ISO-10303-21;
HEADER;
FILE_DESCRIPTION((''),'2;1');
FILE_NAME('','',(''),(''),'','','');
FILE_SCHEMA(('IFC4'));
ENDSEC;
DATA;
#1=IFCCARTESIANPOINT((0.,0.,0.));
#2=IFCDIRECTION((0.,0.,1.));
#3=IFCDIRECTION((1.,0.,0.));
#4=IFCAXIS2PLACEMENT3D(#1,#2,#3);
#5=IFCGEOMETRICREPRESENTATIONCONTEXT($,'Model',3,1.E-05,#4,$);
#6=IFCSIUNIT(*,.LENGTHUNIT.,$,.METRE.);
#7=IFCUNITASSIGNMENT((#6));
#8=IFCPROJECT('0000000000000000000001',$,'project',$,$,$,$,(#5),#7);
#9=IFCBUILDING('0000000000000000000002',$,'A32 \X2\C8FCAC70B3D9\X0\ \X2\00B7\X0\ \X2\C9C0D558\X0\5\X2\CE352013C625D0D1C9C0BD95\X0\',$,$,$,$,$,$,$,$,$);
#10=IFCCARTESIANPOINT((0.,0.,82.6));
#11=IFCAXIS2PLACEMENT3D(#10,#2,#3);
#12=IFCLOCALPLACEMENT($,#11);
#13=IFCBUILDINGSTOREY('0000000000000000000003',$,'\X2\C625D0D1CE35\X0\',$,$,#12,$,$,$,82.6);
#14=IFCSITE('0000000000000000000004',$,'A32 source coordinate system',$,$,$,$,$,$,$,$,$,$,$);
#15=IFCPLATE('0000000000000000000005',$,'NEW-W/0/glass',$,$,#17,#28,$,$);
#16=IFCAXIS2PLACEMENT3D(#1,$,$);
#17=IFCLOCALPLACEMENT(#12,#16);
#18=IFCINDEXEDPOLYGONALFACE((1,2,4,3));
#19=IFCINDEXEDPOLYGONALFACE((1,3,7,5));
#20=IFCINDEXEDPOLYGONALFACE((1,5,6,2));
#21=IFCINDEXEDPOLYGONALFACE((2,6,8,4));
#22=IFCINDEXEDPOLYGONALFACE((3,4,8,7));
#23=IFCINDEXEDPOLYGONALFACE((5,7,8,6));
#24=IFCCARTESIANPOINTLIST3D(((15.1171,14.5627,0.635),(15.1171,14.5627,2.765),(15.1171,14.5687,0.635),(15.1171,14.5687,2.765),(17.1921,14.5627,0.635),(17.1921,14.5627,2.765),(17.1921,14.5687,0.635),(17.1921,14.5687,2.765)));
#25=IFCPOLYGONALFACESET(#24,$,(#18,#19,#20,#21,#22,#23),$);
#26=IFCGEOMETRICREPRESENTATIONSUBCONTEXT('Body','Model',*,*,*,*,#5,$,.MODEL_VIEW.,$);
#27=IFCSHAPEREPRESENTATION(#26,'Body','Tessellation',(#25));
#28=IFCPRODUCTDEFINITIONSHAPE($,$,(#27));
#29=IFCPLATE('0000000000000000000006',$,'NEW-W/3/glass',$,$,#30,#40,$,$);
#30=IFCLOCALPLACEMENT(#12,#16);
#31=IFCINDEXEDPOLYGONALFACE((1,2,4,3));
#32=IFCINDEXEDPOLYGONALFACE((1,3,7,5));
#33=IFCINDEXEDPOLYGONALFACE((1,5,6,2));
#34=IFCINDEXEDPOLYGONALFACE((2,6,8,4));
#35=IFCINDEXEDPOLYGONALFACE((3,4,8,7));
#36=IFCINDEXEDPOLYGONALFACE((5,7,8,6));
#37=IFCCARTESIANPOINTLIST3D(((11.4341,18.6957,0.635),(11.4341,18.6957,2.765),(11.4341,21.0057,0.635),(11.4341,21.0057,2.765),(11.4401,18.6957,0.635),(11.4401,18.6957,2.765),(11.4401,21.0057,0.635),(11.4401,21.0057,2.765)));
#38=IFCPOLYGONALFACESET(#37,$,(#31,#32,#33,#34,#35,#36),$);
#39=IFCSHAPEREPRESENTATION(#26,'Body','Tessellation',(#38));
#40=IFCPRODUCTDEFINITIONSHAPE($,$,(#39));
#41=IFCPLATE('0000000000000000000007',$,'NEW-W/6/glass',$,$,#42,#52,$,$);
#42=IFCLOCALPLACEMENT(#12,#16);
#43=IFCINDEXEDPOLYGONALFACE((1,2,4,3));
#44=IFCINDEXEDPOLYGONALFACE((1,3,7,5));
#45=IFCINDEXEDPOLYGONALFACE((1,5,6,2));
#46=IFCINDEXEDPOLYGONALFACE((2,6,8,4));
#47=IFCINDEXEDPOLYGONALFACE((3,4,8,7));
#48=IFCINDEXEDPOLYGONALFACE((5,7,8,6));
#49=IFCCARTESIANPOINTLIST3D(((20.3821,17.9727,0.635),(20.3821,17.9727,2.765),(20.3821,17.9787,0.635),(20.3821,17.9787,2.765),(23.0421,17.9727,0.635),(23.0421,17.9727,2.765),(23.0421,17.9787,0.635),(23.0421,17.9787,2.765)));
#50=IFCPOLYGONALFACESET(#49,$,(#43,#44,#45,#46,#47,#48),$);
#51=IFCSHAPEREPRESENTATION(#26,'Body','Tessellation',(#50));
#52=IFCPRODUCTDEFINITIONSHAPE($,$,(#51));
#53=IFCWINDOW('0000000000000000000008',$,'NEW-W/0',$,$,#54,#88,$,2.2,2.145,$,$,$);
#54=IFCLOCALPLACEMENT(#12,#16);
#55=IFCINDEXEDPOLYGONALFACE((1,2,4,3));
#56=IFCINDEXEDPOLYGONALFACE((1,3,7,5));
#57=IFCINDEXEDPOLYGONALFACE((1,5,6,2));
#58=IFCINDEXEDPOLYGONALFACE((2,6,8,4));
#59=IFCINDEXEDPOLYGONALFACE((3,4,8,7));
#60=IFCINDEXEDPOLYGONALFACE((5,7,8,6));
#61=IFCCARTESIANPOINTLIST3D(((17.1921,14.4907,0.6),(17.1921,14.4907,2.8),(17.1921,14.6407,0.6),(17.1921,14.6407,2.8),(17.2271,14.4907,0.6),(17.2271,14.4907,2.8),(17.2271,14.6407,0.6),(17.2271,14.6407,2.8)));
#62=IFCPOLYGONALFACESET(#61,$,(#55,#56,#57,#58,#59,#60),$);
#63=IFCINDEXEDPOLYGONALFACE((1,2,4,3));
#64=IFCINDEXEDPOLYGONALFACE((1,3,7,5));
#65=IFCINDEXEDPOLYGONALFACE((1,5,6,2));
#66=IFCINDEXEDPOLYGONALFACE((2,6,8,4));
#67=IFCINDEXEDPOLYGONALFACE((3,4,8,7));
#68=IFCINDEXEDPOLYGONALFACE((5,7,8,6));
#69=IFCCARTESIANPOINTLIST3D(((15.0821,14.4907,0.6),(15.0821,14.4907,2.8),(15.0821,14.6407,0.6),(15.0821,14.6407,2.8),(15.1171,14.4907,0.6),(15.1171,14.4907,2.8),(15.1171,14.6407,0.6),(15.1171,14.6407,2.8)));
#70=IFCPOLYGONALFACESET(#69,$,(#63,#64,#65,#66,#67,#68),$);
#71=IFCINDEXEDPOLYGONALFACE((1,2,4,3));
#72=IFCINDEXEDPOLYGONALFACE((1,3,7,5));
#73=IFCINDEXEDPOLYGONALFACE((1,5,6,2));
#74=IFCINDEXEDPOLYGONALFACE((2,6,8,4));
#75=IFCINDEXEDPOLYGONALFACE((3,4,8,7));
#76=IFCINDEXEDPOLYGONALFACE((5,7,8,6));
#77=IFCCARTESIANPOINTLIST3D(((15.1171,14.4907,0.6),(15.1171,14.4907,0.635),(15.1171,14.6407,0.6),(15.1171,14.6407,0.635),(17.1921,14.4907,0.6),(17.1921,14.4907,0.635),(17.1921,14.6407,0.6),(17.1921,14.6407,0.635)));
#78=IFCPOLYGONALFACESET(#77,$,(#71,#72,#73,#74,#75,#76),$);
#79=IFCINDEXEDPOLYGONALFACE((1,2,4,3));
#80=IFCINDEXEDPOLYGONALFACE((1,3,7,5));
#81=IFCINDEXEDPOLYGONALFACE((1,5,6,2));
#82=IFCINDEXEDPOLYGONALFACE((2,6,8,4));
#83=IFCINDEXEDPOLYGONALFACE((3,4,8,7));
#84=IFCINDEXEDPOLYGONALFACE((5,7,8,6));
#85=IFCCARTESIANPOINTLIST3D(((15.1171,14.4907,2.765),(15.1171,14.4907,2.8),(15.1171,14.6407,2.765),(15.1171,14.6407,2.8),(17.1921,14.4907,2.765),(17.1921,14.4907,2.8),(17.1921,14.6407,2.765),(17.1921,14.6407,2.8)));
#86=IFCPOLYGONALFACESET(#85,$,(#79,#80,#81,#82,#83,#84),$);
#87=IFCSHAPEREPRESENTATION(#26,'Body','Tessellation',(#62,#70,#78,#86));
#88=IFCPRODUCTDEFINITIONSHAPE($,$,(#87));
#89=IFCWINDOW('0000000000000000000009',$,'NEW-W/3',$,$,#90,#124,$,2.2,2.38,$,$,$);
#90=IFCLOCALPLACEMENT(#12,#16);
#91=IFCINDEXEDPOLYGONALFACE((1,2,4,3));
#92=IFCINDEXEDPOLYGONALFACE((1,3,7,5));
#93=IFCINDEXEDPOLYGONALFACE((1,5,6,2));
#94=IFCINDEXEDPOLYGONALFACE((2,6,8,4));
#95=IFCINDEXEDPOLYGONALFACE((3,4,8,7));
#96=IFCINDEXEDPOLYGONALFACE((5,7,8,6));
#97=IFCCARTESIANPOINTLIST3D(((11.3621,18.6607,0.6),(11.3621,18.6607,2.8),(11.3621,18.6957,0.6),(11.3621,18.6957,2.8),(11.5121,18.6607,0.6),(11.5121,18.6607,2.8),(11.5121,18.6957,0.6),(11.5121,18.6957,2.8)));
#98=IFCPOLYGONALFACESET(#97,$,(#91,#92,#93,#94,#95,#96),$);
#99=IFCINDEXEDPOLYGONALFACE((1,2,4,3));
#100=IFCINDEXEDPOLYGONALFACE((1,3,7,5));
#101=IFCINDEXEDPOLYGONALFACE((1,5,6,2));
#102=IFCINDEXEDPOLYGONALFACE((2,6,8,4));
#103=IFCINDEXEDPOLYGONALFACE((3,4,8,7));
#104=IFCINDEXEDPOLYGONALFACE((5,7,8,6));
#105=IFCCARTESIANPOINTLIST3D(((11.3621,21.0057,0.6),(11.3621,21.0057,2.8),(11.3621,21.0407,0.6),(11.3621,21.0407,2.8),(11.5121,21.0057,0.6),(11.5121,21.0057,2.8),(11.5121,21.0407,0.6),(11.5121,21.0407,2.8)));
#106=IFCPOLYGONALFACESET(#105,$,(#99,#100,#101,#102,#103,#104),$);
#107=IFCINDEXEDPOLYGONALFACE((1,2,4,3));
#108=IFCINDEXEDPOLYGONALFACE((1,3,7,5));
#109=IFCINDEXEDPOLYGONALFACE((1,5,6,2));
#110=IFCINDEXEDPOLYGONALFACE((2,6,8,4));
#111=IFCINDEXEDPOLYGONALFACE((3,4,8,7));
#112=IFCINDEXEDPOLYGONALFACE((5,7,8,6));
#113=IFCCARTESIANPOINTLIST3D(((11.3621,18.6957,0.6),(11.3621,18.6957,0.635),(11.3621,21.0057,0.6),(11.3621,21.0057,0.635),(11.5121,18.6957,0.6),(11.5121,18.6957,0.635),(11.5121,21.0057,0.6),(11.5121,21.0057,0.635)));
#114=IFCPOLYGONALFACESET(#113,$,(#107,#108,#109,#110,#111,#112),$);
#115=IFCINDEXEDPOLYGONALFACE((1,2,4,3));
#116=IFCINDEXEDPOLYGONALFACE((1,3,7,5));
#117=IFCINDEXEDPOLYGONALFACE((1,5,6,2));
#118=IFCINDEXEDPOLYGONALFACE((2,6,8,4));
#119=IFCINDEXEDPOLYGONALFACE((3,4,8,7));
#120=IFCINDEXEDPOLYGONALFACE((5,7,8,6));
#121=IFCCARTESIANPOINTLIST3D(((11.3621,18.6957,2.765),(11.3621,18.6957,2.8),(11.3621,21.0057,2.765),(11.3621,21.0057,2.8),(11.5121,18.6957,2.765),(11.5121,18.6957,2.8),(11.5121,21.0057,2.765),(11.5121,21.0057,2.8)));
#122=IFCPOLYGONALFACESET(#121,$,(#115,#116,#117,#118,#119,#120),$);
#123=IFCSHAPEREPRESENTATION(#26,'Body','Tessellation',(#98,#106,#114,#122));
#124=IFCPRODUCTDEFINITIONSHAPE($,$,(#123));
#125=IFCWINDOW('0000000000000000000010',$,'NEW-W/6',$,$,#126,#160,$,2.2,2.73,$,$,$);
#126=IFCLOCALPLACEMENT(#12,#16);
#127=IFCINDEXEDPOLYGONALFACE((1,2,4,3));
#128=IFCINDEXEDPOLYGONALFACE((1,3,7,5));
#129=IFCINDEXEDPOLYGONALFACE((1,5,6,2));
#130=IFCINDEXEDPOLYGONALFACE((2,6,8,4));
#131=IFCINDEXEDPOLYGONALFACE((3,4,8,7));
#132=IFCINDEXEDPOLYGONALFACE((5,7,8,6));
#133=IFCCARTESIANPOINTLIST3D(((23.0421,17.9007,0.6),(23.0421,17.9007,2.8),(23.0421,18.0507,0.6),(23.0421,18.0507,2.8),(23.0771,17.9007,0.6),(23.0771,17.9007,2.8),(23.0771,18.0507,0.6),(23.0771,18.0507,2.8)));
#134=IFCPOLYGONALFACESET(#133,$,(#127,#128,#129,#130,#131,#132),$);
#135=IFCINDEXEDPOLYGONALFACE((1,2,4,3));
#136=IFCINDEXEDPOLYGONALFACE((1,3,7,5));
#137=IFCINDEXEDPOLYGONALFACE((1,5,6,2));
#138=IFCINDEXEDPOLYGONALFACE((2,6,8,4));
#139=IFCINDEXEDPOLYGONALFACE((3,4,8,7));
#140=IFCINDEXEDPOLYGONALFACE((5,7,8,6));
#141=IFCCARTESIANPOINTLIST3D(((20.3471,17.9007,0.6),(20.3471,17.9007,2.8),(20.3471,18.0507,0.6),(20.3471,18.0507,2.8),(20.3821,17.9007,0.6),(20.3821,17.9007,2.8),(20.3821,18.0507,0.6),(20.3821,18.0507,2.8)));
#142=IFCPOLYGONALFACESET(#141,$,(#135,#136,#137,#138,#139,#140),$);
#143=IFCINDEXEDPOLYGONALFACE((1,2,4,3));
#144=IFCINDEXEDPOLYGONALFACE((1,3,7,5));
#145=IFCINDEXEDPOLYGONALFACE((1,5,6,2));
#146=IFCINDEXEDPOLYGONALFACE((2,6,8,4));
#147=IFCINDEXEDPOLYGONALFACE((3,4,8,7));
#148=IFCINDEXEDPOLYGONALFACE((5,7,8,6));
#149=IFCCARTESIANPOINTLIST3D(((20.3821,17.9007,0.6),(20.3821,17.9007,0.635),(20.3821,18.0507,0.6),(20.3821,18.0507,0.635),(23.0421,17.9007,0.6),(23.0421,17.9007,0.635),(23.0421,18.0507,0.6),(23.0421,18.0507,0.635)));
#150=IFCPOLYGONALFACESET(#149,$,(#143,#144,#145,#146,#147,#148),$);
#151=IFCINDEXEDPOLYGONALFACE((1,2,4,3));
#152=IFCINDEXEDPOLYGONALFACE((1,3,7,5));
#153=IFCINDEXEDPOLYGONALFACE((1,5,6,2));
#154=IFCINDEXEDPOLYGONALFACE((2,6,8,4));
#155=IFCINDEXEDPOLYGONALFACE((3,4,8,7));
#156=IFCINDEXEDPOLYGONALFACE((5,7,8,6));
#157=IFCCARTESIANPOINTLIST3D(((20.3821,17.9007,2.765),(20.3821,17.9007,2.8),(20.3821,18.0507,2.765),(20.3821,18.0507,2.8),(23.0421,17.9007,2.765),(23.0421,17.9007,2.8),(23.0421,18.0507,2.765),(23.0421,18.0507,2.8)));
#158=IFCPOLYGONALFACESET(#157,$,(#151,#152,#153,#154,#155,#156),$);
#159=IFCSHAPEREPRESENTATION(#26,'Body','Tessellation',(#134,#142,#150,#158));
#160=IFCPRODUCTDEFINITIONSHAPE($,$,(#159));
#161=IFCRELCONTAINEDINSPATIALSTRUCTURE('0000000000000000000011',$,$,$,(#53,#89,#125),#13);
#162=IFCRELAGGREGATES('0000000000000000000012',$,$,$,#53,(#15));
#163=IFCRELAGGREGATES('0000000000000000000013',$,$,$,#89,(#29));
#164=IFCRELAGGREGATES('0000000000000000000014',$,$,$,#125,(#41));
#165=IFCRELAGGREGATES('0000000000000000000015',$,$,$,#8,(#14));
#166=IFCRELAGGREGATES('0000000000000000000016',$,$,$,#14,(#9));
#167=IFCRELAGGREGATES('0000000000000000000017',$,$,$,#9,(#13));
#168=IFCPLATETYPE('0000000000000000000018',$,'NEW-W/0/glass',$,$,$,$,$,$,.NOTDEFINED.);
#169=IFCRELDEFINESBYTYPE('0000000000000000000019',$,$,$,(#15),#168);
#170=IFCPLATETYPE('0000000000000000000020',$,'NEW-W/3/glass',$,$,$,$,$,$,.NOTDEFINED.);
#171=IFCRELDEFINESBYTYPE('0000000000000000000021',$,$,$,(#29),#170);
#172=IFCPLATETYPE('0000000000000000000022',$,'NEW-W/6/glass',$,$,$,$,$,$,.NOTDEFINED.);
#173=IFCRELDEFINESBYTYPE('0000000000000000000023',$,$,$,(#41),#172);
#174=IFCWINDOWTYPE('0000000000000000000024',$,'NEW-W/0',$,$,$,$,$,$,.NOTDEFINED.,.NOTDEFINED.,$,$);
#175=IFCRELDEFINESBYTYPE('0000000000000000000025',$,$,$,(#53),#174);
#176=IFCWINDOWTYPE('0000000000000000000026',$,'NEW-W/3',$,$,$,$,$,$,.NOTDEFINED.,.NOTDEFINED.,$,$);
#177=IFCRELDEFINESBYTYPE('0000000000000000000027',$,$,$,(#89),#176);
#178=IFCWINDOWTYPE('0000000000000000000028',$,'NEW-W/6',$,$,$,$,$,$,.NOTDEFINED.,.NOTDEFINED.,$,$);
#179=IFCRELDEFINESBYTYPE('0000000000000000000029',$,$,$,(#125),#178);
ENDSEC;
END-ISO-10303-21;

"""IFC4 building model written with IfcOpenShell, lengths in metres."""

from ifc_helpers import new_model, si_unit, frame, origin, origin_with_axes, place, context, subcontext, project, spatial, polyline, outline, extrude, source, transform, mapped, type_object, type_shapes, element, aggregate, save


model = new_model("IFC4")

# Units and contexts
model_context = context("Model", 3, precision=1e-05, world=origin_with_axes())
body_context = subcontext(model_context, "Body", "Model", "MODEL_VIEW")
ifc_project = project(units=[si_unit("LENGTHUNIT", "METRE")], contexts=[model_context])

# Plates
plate_type_1 = type_object("IfcPlateType", Name="NEW-W/0/glass", PredefinedType="NOTDEFINED")
shared_shape_1 = source(origin(), body_context, "Body", "SweptSolid", [
    extrude(outline(polyline([(17.1921, 14.5627), (15.1171, 14.5627), (15.1171, 14.5687), (17.1921, 14.5687), (17.1921, 14.5627)])), frame((0.0, 0.0, 0.635)), (0.0, 0.0, 1.0), 2.13),
])
type_shapes(plate_type_1, [shared_shape_1])
storey_placement = place(None, frame((0.0, 0.0, 82.6), z_axis=(0.0, 0.0, 1.0), x_axis=(1.0, 0.0, 0.0)))
window_1_placement = place(storey_placement, origin_with_axes())
plate_1_placement = place(window_1_placement, origin_with_axes())
plate_1 = element("IfcPlate", 1, at=plate_1_placement, type_object=plate_type_1, Name="NEW-W/0/glass", context=body_context, shape_type="MappedRepresentation", body=[
    mapped(shared_shape_1, transform((0.0, 0.0, 0.0), scale=1.0)),
])
plate_type_2 = type_object("IfcPlateType", Name="NEW-W/3/glass", PredefinedType="NOTDEFINED")
shared_shape_2 = source(origin(), body_context, "Body", "SweptSolid", [
    extrude(outline(polyline([(11.4401, 18.6957), (11.4341, 18.6957), (11.4341, 21.0057), (11.4401, 21.0057), (11.4401, 18.6957)])), frame((0.0, 0.0, 0.635)), (0.0, 0.0, 1.0), 2.13),
])
type_shapes(plate_type_2, [shared_shape_2])
window_2_placement = place(storey_placement, origin_with_axes())
plate_2_placement = place(window_2_placement, origin_with_axes())
plate_2 = element("IfcPlate", 2, at=plate_2_placement, type_object=plate_type_2, Name="NEW-W/3/glass", context=body_context, shape_type="MappedRepresentation", body=[
    mapped(shared_shape_2, transform((0.0, 0.0, 0.0), scale=1.0)),
])
plate_type_3 = type_object("IfcPlateType", Name="NEW-W/6/glass", PredefinedType="NOTDEFINED")
shared_shape_3 = source(origin(), body_context, "Body", "SweptSolid", [
    extrude(outline(polyline([(23.0421, 17.9727), (20.3821, 17.9727), (20.3821, 17.9787), (23.0421, 17.9787), (23.0421, 17.9727)])), frame((0.0, 0.0, 0.635)), (0.0, 0.0, 1.0), 2.13),
])
type_shapes(plate_type_3, [shared_shape_3])
window_3_placement = place(storey_placement, origin_with_axes())
plate_3_placement = place(window_3_placement, origin_with_axes())
plate_3 = element("IfcPlate", 3, at=plate_3_placement, type_object=plate_type_3, Name="NEW-W/6/glass", context=body_context, shape_type="MappedRepresentation", body=[
    mapped(shared_shape_3, transform((0.0, 0.0, 0.0), scale=1.0)),
])

# Site, building, storey
site = spatial("IfcSite", under=ifc_project, Name="A32 source coordinate system")
building = spatial("IfcBuilding", under=site, Name="A32 주거동 · 지하5층–옥탑지붕")
storey = spatial("IfcBuildingStorey", under=building, at=storey_placement, Name="옥탑층", Elevation=82.6)

# Windows
window_type_1 = type_object("IfcWindowType", Name="NEW-W/0", PartitioningType="NOTDEFINED", PredefinedType="NOTDEFINED")
shared_shape_4 = source(origin(), body_context, "Body", "SweptSolid", [
    extrude(outline(polyline([(17.1921, 14.4907), (17.1921, 14.6407), (17.2271, 14.6407), (17.2271, 14.4907), (17.1921, 14.4907)])), frame((0.0, 0.0, 0.6)), (0.0, 0.0, 1.0), 2.2),
    extrude(outline(polyline([(15.0821, 14.4907), (15.0821, 14.6407), (15.1171, 14.6407), (15.1171, 14.4907), (15.0821, 14.4907)])), frame((0.0, 0.0, 0.6)), (0.0, 0.0, 1.0), 2.2),
    extrude(outline(polyline([(17.1921, 14.4907), (17.1921, 14.6407), (15.1171, 14.6407), (15.1171, 14.4907), (17.1921, 14.4907)])), frame((0.0, 0.0, 0.6)), (0.0, 0.0, 1.0), 0.035),
    extrude(outline(polyline([(17.1921, 14.4907), (17.1921, 14.6407), (15.1171, 14.6407), (15.1171, 14.4907), (17.1921, 14.4907)])), frame((0.0, 0.0, 2.765)), (0.0, 0.0, 1.0), 0.035),
])
type_shapes(window_type_1, [shared_shape_4])
window_1 = element("IfcWindow", 4, at=window_1_placement, inside=storey, type_object=window_type_1, Name="NEW-W/0", OverallHeight=2.2, OverallWidth=2.145, context=body_context, shape_type="MappedRepresentation", body=[
    mapped(shared_shape_4, transform((0.0, 0.0, 0.0), scale=1.0)),
])
aggregate(window_1, [plate_1])
window_type_2 = type_object("IfcWindowType", Name="NEW-W/3", PartitioningType="NOTDEFINED", PredefinedType="NOTDEFINED")
shared_shape_5 = source(origin(), body_context, "Body", "SweptSolid", [
    extrude(outline(polyline([(11.3621, 18.6607), (11.3621, 18.6957), (11.5121, 18.6957), (11.5121, 18.6607), (11.3621, 18.6607)])), frame((0.0, 0.0, 0.6)), (0.0, 0.0, 1.0), 2.2),
    extrude(outline(polyline([(11.3621, 21.0057), (11.3621, 21.0407), (11.5121, 21.0407), (11.5121, 21.0057), (11.3621, 21.0057)])), frame((0.0, 0.0, 0.6)), (0.0, 0.0, 1.0), 2.2),
    extrude(outline(polyline([(11.5121, 18.6957), (11.5121, 21.0057), (11.3621, 21.0057), (11.3621, 18.6957), (11.5121, 18.6957)])), frame((0.0, 0.0, 0.6)), (0.0, 0.0, 1.0), 0.035),
    extrude(outline(polyline([(11.5121, 18.6957), (11.5121, 21.0057), (11.3621, 21.0057), (11.3621, 18.6957), (11.5121, 18.6957)])), frame((0.0, 0.0, 2.765)), (0.0, 0.0, 1.0), 0.035),
])
type_shapes(window_type_2, [shared_shape_5])
window_2 = element("IfcWindow", 5, at=window_2_placement, inside=storey, type_object=window_type_2, Name="NEW-W/3", OverallHeight=2.2, OverallWidth=2.38, context=body_context, shape_type="MappedRepresentation", body=[
    mapped(shared_shape_5, transform((0.0, 0.0, 0.0), scale=1.0)),
])
aggregate(window_2, [plate_2])
window_type_3 = type_object("IfcWindowType", Name="NEW-W/6", PartitioningType="NOTDEFINED", PredefinedType="NOTDEFINED")
shared_shape_6 = source(origin(), body_context, "Body", "SweptSolid", [
    extrude(outline(polyline([(23.0421, 17.9007), (23.0421, 18.0507), (23.0771, 18.0507), (23.0771, 17.9007), (23.0421, 17.9007)])), frame((0.0, 0.0, 0.6)), (0.0, 0.0, 1.0), 2.2),
    extrude(outline(polyline([(20.3471, 17.9007), (20.3471, 18.0507), (20.3821, 18.0507), (20.3821, 17.9007), (20.3471, 17.9007)])), frame((0.0, 0.0, 0.6)), (0.0, 0.0, 1.0), 2.2),
    extrude(outline(polyline([(23.0421, 17.9007), (23.0421, 18.0507), (20.3821, 18.0507), (20.3821, 17.9007), (23.0421, 17.9007)])), frame((0.0, 0.0, 0.6)), (0.0, 0.0, 1.0), 0.035),
    extrude(outline(polyline([(23.0421, 17.9007), (23.0421, 18.0507), (20.3821, 18.0507), (20.3821, 17.9007), (23.0421, 17.9007)])), frame((0.0, 0.0, 2.765)), (0.0, 0.0, 1.0), 0.035),
])
type_shapes(window_type_3, [shared_shape_6])
window_3 = element("IfcWindow", 6, at=window_3_placement, inside=storey, type_object=window_type_3, Name="NEW-W/6", OverallHeight=2.2, OverallWidth=2.73, context=body_context, shape_type="MappedRepresentation", body=[
    mapped(shared_shape_6, transform((0.0, 0.0, 0.0), scale=1.0)),
])
aggregate(window_3, [plate_3])

save(model, "model.ifc")
